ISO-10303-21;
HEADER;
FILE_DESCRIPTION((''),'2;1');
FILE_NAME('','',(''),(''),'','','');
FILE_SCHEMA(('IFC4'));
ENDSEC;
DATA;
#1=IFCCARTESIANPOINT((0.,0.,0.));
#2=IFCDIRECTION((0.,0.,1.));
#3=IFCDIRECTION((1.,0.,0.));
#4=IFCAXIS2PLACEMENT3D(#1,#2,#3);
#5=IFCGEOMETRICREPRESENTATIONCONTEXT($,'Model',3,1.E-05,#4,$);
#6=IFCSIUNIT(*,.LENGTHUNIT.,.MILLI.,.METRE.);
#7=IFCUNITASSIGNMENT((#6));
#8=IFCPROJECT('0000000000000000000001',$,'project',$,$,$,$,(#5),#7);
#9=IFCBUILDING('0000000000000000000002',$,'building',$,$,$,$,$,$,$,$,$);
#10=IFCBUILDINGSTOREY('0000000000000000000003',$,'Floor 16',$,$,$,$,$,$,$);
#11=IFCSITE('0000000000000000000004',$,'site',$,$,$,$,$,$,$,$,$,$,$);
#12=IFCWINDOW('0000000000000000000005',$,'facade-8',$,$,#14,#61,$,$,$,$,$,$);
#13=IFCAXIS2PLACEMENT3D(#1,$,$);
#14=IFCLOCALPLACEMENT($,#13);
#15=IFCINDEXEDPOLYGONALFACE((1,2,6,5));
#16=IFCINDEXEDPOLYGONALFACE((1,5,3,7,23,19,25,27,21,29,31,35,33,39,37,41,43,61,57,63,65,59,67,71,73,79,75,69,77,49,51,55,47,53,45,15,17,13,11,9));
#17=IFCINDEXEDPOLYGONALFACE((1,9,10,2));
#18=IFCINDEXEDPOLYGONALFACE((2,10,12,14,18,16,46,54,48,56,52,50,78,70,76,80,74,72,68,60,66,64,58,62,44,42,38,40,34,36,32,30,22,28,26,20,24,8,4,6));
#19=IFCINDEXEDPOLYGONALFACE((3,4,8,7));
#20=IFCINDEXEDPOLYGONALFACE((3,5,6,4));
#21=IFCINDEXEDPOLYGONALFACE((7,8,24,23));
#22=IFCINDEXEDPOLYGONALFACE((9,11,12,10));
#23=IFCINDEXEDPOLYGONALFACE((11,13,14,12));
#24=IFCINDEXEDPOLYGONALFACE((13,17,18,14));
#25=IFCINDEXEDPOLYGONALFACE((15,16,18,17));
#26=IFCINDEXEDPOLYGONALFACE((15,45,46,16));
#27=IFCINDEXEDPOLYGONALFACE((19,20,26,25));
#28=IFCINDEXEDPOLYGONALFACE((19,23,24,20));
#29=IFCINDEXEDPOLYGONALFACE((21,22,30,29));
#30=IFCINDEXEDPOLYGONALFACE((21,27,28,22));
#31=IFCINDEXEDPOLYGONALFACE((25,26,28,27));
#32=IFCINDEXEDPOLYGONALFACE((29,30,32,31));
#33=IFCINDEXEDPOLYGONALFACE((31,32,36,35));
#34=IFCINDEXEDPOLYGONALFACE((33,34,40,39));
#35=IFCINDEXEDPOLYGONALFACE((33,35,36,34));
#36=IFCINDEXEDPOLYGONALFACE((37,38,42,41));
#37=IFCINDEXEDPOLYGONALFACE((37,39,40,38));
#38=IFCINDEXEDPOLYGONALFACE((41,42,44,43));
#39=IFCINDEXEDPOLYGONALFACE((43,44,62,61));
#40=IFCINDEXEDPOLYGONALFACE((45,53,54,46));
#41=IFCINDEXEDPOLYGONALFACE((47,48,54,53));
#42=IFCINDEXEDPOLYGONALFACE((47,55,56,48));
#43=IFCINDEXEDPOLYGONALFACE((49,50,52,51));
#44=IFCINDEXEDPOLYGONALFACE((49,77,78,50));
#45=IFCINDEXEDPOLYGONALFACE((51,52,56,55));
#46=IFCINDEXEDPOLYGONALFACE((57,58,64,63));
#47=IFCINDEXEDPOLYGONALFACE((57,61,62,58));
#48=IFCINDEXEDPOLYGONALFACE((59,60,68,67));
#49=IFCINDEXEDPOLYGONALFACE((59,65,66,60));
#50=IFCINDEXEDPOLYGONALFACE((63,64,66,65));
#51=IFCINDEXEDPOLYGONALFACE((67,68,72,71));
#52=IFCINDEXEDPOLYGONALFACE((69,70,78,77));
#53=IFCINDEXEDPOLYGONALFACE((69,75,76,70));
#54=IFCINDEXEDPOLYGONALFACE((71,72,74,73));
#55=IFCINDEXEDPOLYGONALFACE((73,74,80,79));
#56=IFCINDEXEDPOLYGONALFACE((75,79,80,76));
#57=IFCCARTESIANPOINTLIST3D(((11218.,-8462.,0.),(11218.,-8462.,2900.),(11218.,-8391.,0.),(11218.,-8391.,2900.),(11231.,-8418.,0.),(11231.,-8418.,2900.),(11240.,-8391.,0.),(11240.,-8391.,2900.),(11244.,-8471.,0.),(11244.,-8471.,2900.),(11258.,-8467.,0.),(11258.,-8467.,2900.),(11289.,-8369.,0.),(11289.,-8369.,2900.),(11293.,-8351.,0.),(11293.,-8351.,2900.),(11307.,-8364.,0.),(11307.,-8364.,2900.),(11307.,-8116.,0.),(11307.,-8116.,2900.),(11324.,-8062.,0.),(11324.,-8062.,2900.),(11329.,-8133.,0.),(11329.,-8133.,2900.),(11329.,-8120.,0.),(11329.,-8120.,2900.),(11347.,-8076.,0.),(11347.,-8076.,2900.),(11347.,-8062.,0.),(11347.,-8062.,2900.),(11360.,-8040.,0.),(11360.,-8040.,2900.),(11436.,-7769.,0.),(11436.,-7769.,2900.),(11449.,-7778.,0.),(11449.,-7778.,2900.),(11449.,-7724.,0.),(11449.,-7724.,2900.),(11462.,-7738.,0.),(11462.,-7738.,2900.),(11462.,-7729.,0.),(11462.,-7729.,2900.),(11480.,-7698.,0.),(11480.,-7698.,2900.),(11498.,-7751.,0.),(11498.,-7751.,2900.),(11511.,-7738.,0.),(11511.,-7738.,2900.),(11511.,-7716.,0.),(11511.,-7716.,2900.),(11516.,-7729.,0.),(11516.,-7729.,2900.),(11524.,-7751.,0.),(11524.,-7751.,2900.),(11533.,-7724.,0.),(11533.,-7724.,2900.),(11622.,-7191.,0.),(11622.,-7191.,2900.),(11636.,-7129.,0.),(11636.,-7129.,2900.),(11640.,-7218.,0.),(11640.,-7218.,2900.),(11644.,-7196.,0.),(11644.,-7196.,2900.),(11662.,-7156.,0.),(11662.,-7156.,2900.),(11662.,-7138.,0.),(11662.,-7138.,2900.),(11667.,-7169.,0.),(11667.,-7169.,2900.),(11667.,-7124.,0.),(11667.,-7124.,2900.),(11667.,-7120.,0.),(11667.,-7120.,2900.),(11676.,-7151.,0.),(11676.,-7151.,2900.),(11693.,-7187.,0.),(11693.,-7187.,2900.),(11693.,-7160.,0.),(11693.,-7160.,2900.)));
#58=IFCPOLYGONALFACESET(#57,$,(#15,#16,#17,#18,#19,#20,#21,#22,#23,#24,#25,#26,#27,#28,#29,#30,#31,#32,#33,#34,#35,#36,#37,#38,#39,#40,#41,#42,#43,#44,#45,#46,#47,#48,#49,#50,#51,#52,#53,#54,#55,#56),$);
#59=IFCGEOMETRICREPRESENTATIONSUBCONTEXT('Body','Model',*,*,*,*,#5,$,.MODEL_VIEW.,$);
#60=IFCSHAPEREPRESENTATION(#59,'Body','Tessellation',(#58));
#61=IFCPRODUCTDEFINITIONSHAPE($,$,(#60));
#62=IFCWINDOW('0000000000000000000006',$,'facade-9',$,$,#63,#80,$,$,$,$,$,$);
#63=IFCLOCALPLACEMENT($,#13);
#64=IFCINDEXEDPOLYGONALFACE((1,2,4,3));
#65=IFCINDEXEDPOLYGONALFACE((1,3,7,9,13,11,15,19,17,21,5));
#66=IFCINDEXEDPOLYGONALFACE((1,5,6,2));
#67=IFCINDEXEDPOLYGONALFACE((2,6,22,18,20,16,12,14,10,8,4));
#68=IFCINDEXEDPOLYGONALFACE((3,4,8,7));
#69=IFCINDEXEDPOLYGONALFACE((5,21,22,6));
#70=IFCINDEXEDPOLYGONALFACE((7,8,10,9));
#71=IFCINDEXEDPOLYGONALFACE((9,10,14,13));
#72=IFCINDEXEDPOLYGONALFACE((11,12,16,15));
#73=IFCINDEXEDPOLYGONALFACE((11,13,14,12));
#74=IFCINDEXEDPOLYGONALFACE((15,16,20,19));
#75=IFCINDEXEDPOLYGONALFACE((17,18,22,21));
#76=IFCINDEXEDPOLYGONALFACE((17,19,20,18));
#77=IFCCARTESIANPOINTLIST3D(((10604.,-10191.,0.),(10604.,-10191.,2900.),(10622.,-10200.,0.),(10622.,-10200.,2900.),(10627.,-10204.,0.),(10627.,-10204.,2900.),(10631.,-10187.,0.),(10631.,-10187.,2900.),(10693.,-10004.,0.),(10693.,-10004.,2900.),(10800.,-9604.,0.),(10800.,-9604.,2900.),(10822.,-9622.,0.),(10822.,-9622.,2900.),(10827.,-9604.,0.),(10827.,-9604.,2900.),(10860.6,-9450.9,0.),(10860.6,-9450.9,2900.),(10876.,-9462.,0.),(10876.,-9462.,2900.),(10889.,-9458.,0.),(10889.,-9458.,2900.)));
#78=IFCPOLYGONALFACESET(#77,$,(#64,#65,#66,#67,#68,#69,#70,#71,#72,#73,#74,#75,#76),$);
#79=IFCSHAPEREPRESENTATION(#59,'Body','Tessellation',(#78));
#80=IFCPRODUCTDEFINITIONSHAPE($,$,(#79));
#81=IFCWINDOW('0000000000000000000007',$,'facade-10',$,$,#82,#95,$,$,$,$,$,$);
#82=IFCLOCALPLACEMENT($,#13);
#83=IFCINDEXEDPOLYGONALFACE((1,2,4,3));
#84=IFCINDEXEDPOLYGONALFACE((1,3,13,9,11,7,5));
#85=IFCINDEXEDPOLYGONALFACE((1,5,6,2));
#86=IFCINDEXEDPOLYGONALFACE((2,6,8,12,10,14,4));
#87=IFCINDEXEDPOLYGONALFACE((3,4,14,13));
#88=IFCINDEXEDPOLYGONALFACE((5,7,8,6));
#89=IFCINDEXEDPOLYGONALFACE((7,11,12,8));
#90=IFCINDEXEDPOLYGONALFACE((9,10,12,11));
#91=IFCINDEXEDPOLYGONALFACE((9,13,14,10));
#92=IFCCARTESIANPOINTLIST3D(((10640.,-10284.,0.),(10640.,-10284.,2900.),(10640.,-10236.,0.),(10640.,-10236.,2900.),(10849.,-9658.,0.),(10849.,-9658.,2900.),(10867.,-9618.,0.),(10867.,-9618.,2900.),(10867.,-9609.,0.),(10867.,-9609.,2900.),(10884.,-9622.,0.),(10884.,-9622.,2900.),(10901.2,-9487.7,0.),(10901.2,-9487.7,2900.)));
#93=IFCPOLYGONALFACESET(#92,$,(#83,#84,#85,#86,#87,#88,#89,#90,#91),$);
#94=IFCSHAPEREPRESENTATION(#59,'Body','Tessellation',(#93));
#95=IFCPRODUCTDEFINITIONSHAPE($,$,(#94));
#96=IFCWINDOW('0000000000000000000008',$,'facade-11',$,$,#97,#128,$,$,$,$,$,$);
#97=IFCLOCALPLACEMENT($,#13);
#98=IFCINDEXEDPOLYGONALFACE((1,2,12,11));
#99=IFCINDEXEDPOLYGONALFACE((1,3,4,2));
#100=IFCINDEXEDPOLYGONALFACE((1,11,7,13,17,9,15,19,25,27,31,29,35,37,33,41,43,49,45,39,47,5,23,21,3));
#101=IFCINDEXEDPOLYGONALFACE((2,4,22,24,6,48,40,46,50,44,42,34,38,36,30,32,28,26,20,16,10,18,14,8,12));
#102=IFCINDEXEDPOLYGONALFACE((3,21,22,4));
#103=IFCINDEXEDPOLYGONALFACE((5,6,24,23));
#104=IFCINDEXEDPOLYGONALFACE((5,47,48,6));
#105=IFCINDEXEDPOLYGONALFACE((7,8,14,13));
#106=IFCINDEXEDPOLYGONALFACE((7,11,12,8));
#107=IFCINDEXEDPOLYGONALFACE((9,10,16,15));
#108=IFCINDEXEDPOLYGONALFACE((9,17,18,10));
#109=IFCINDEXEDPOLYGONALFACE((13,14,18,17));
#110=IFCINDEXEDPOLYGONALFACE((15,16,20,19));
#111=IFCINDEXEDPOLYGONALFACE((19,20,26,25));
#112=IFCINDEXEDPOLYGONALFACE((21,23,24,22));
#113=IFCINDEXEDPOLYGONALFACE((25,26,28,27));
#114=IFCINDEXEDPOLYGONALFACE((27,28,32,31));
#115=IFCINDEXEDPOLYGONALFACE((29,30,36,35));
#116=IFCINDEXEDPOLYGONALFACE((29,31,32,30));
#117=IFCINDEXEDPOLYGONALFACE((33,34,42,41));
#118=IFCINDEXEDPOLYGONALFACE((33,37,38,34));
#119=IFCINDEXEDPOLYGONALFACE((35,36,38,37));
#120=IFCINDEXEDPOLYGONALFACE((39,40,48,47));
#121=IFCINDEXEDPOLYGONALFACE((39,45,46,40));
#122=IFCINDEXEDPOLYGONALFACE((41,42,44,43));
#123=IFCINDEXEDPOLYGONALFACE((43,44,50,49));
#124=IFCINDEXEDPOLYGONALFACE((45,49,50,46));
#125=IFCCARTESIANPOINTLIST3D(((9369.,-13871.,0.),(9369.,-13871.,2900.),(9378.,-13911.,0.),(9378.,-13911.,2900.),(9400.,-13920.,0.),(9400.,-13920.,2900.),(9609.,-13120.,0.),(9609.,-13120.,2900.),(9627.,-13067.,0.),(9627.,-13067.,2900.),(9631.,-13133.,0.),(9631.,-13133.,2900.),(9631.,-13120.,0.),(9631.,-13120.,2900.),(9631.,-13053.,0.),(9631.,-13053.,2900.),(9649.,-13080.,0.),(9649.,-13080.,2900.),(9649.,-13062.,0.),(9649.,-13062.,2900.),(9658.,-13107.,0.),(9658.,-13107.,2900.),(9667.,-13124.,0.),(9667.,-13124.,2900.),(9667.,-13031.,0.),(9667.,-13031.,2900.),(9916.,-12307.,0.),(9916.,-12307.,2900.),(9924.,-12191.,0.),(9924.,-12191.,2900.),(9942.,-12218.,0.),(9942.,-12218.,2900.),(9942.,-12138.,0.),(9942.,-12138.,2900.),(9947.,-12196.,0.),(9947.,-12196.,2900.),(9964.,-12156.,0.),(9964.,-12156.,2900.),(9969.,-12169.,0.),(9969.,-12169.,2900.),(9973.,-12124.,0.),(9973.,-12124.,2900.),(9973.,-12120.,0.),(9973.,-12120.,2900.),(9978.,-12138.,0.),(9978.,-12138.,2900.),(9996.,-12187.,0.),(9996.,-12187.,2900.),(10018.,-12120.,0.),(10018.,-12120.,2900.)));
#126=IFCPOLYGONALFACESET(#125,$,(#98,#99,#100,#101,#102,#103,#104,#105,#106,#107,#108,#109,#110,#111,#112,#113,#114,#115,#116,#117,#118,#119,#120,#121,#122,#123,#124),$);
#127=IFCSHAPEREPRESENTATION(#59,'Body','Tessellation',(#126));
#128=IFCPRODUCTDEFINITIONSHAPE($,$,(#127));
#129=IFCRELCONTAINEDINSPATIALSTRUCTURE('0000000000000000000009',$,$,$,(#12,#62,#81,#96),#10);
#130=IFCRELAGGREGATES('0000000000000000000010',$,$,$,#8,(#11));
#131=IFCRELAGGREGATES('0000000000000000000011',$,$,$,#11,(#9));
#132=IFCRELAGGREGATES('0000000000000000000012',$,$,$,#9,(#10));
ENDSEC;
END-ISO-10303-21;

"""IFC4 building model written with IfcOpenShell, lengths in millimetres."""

from ifc_helpers import new_model, si_unit, origin_with_axes, place, context, subcontext, project, spatial, indexed_curve, outline, extrude, element, save


model = new_model("IFC4")

# Units and contexts
model_context = context("Model", 3, precision=1e-05, world=origin_with_axes())
body_context = subcontext(model_context, "Body", "Model", "MODEL_VIEW")
ifc_project = project(units=[si_unit("LENGTHUNIT", "METRE", prefix="MILLI")], contexts=[model_context])

# Site, building, storey
site = spatial("IfcSite", under=ifc_project, Name="site")
building = spatial("IfcBuilding", under=site, Name="building")
storey = spatial("IfcBuildingStorey", under=building, Name="Floor 16")

# Windows
window_1_placement = place(None, origin_with_axes())
element("IfcWindow", 1, at=window_1_placement, inside=storey, Name="facade-8", context=body_context, shape_type="SweptSolid", body=[
    extrude(outline(indexed_curve([(11667.0, -7120.0), (11667.0, -7124.0), (11662.0, -7138.0), (11636.0, -7129.0), (11662.0, -7156.0), (11644.0, -7196.0), (11622.0, -7191.0), (11640.0, -7218.0), (11480.0, -7698.0), (11462.0, -7729.0), (11449.0, -7724.0), (11462.0, -7738.0), (11436.0, -7769.0), (11449.0, -7778.0), (11360.0, -8040.0), (11347.0, -8062.0), (11324.0, -8062.0), (11347.0, -8076.0), (11329.0, -8120.0), (11307.0, -8116.0), (11329.0, -8133.0), (11240.0, -8391.0), (11218.0, -8391.0), (11231.0, -8418.0), (11218.0, -8462.0), (11244.0, -8471.0), (11258.0, -8467.0), (11289.0, -8369.0), (11307.0, -8364.0), (11293.0, -8351.0), (11498.0, -7751.0), (11524.0, -7751.0), (11511.0, -7738.0), (11533.0, -7724.0), (11516.0, -7729.0), (11511.0, -7716.0), (11693.0, -7187.0), (11667.0, -7169.0), (11676.0, -7151.0), (11693.0, -7160.0)])), None, (0.0, 0.0, 1.0), 2900.0),
])
window_2_placement = place(None, origin_with_axes())
element("IfcWindow", 2, at=window_2_placement, inside=storey, Name="facade-9", context=body_context, shape_type="SweptSolid", body=[
    extrude(outline(indexed_curve([(10860.6, -9450.9), (10876.0, -9462.0), (10827.0, -9604.0), (10800.0, -9604.0), (10822.0, -9622.0), (10693.0, -10004.0), (10631.0, -10187.0), (10622.0, -10200.0), (10604.0, -10191.0), (10627.0, -10204.0), (10889.0, -9458.0)])), None, (0.0, 0.0, 1.0), 2900.0),
])
window_3_placement = place(None, origin_with_axes())
element("IfcWindow", 3, at=window_3_placement, inside=storey, Name="facade-10", context=body_context, shape_type="SweptSolid", body=[
    extrude(outline(indexed_curve([(10901.2, -9487.7), (10640.0, -10236.0), (10640.0, -10284.0), (10849.0, -9658.0), (10867.0, -9618.0), (10884.0, -9622.0), (10867.0, -9609.0)])), None, (0.0, 0.0, 1.0), 2900.0),
])
window_4_placement = place(None, origin_with_axes())
element("IfcWindow", 4, at=window_4_placement, inside=storey, Name="facade-11", context=body_context, shape_type="SweptSolid", body=[
    extrude(outline(indexed_curve([(9973.0, -12120.0), (9973.0, -12124.0), (9942.0, -12138.0), (9964.0, -12156.0), (9947.0, -12196.0), (9924.0, -12191.0), (9942.0, -12218.0), (9916.0, -12307.0), (9667.0, -13031.0), (9649.0, -13062.0), (9631.0, -13053.0), (9627.0, -13067.0), (9649.0, -13080.0), (9631.0, -13120.0), (9609.0, -13120.0), (9631.0, -13133.0), (9369.0, -13871.0), (9378.0, -13911.0), (9658.0, -13107.0), (9667.0, -13124.0), (9400.0, -13920.0), (9996.0, -12187.0), (9969.0, -12169.0), (9978.0, -12138.0), (10018.0, -12120.0)])), None, (0.0, 0.0, 1.0), 2900.0),
])

save(model, "model.ifc")
